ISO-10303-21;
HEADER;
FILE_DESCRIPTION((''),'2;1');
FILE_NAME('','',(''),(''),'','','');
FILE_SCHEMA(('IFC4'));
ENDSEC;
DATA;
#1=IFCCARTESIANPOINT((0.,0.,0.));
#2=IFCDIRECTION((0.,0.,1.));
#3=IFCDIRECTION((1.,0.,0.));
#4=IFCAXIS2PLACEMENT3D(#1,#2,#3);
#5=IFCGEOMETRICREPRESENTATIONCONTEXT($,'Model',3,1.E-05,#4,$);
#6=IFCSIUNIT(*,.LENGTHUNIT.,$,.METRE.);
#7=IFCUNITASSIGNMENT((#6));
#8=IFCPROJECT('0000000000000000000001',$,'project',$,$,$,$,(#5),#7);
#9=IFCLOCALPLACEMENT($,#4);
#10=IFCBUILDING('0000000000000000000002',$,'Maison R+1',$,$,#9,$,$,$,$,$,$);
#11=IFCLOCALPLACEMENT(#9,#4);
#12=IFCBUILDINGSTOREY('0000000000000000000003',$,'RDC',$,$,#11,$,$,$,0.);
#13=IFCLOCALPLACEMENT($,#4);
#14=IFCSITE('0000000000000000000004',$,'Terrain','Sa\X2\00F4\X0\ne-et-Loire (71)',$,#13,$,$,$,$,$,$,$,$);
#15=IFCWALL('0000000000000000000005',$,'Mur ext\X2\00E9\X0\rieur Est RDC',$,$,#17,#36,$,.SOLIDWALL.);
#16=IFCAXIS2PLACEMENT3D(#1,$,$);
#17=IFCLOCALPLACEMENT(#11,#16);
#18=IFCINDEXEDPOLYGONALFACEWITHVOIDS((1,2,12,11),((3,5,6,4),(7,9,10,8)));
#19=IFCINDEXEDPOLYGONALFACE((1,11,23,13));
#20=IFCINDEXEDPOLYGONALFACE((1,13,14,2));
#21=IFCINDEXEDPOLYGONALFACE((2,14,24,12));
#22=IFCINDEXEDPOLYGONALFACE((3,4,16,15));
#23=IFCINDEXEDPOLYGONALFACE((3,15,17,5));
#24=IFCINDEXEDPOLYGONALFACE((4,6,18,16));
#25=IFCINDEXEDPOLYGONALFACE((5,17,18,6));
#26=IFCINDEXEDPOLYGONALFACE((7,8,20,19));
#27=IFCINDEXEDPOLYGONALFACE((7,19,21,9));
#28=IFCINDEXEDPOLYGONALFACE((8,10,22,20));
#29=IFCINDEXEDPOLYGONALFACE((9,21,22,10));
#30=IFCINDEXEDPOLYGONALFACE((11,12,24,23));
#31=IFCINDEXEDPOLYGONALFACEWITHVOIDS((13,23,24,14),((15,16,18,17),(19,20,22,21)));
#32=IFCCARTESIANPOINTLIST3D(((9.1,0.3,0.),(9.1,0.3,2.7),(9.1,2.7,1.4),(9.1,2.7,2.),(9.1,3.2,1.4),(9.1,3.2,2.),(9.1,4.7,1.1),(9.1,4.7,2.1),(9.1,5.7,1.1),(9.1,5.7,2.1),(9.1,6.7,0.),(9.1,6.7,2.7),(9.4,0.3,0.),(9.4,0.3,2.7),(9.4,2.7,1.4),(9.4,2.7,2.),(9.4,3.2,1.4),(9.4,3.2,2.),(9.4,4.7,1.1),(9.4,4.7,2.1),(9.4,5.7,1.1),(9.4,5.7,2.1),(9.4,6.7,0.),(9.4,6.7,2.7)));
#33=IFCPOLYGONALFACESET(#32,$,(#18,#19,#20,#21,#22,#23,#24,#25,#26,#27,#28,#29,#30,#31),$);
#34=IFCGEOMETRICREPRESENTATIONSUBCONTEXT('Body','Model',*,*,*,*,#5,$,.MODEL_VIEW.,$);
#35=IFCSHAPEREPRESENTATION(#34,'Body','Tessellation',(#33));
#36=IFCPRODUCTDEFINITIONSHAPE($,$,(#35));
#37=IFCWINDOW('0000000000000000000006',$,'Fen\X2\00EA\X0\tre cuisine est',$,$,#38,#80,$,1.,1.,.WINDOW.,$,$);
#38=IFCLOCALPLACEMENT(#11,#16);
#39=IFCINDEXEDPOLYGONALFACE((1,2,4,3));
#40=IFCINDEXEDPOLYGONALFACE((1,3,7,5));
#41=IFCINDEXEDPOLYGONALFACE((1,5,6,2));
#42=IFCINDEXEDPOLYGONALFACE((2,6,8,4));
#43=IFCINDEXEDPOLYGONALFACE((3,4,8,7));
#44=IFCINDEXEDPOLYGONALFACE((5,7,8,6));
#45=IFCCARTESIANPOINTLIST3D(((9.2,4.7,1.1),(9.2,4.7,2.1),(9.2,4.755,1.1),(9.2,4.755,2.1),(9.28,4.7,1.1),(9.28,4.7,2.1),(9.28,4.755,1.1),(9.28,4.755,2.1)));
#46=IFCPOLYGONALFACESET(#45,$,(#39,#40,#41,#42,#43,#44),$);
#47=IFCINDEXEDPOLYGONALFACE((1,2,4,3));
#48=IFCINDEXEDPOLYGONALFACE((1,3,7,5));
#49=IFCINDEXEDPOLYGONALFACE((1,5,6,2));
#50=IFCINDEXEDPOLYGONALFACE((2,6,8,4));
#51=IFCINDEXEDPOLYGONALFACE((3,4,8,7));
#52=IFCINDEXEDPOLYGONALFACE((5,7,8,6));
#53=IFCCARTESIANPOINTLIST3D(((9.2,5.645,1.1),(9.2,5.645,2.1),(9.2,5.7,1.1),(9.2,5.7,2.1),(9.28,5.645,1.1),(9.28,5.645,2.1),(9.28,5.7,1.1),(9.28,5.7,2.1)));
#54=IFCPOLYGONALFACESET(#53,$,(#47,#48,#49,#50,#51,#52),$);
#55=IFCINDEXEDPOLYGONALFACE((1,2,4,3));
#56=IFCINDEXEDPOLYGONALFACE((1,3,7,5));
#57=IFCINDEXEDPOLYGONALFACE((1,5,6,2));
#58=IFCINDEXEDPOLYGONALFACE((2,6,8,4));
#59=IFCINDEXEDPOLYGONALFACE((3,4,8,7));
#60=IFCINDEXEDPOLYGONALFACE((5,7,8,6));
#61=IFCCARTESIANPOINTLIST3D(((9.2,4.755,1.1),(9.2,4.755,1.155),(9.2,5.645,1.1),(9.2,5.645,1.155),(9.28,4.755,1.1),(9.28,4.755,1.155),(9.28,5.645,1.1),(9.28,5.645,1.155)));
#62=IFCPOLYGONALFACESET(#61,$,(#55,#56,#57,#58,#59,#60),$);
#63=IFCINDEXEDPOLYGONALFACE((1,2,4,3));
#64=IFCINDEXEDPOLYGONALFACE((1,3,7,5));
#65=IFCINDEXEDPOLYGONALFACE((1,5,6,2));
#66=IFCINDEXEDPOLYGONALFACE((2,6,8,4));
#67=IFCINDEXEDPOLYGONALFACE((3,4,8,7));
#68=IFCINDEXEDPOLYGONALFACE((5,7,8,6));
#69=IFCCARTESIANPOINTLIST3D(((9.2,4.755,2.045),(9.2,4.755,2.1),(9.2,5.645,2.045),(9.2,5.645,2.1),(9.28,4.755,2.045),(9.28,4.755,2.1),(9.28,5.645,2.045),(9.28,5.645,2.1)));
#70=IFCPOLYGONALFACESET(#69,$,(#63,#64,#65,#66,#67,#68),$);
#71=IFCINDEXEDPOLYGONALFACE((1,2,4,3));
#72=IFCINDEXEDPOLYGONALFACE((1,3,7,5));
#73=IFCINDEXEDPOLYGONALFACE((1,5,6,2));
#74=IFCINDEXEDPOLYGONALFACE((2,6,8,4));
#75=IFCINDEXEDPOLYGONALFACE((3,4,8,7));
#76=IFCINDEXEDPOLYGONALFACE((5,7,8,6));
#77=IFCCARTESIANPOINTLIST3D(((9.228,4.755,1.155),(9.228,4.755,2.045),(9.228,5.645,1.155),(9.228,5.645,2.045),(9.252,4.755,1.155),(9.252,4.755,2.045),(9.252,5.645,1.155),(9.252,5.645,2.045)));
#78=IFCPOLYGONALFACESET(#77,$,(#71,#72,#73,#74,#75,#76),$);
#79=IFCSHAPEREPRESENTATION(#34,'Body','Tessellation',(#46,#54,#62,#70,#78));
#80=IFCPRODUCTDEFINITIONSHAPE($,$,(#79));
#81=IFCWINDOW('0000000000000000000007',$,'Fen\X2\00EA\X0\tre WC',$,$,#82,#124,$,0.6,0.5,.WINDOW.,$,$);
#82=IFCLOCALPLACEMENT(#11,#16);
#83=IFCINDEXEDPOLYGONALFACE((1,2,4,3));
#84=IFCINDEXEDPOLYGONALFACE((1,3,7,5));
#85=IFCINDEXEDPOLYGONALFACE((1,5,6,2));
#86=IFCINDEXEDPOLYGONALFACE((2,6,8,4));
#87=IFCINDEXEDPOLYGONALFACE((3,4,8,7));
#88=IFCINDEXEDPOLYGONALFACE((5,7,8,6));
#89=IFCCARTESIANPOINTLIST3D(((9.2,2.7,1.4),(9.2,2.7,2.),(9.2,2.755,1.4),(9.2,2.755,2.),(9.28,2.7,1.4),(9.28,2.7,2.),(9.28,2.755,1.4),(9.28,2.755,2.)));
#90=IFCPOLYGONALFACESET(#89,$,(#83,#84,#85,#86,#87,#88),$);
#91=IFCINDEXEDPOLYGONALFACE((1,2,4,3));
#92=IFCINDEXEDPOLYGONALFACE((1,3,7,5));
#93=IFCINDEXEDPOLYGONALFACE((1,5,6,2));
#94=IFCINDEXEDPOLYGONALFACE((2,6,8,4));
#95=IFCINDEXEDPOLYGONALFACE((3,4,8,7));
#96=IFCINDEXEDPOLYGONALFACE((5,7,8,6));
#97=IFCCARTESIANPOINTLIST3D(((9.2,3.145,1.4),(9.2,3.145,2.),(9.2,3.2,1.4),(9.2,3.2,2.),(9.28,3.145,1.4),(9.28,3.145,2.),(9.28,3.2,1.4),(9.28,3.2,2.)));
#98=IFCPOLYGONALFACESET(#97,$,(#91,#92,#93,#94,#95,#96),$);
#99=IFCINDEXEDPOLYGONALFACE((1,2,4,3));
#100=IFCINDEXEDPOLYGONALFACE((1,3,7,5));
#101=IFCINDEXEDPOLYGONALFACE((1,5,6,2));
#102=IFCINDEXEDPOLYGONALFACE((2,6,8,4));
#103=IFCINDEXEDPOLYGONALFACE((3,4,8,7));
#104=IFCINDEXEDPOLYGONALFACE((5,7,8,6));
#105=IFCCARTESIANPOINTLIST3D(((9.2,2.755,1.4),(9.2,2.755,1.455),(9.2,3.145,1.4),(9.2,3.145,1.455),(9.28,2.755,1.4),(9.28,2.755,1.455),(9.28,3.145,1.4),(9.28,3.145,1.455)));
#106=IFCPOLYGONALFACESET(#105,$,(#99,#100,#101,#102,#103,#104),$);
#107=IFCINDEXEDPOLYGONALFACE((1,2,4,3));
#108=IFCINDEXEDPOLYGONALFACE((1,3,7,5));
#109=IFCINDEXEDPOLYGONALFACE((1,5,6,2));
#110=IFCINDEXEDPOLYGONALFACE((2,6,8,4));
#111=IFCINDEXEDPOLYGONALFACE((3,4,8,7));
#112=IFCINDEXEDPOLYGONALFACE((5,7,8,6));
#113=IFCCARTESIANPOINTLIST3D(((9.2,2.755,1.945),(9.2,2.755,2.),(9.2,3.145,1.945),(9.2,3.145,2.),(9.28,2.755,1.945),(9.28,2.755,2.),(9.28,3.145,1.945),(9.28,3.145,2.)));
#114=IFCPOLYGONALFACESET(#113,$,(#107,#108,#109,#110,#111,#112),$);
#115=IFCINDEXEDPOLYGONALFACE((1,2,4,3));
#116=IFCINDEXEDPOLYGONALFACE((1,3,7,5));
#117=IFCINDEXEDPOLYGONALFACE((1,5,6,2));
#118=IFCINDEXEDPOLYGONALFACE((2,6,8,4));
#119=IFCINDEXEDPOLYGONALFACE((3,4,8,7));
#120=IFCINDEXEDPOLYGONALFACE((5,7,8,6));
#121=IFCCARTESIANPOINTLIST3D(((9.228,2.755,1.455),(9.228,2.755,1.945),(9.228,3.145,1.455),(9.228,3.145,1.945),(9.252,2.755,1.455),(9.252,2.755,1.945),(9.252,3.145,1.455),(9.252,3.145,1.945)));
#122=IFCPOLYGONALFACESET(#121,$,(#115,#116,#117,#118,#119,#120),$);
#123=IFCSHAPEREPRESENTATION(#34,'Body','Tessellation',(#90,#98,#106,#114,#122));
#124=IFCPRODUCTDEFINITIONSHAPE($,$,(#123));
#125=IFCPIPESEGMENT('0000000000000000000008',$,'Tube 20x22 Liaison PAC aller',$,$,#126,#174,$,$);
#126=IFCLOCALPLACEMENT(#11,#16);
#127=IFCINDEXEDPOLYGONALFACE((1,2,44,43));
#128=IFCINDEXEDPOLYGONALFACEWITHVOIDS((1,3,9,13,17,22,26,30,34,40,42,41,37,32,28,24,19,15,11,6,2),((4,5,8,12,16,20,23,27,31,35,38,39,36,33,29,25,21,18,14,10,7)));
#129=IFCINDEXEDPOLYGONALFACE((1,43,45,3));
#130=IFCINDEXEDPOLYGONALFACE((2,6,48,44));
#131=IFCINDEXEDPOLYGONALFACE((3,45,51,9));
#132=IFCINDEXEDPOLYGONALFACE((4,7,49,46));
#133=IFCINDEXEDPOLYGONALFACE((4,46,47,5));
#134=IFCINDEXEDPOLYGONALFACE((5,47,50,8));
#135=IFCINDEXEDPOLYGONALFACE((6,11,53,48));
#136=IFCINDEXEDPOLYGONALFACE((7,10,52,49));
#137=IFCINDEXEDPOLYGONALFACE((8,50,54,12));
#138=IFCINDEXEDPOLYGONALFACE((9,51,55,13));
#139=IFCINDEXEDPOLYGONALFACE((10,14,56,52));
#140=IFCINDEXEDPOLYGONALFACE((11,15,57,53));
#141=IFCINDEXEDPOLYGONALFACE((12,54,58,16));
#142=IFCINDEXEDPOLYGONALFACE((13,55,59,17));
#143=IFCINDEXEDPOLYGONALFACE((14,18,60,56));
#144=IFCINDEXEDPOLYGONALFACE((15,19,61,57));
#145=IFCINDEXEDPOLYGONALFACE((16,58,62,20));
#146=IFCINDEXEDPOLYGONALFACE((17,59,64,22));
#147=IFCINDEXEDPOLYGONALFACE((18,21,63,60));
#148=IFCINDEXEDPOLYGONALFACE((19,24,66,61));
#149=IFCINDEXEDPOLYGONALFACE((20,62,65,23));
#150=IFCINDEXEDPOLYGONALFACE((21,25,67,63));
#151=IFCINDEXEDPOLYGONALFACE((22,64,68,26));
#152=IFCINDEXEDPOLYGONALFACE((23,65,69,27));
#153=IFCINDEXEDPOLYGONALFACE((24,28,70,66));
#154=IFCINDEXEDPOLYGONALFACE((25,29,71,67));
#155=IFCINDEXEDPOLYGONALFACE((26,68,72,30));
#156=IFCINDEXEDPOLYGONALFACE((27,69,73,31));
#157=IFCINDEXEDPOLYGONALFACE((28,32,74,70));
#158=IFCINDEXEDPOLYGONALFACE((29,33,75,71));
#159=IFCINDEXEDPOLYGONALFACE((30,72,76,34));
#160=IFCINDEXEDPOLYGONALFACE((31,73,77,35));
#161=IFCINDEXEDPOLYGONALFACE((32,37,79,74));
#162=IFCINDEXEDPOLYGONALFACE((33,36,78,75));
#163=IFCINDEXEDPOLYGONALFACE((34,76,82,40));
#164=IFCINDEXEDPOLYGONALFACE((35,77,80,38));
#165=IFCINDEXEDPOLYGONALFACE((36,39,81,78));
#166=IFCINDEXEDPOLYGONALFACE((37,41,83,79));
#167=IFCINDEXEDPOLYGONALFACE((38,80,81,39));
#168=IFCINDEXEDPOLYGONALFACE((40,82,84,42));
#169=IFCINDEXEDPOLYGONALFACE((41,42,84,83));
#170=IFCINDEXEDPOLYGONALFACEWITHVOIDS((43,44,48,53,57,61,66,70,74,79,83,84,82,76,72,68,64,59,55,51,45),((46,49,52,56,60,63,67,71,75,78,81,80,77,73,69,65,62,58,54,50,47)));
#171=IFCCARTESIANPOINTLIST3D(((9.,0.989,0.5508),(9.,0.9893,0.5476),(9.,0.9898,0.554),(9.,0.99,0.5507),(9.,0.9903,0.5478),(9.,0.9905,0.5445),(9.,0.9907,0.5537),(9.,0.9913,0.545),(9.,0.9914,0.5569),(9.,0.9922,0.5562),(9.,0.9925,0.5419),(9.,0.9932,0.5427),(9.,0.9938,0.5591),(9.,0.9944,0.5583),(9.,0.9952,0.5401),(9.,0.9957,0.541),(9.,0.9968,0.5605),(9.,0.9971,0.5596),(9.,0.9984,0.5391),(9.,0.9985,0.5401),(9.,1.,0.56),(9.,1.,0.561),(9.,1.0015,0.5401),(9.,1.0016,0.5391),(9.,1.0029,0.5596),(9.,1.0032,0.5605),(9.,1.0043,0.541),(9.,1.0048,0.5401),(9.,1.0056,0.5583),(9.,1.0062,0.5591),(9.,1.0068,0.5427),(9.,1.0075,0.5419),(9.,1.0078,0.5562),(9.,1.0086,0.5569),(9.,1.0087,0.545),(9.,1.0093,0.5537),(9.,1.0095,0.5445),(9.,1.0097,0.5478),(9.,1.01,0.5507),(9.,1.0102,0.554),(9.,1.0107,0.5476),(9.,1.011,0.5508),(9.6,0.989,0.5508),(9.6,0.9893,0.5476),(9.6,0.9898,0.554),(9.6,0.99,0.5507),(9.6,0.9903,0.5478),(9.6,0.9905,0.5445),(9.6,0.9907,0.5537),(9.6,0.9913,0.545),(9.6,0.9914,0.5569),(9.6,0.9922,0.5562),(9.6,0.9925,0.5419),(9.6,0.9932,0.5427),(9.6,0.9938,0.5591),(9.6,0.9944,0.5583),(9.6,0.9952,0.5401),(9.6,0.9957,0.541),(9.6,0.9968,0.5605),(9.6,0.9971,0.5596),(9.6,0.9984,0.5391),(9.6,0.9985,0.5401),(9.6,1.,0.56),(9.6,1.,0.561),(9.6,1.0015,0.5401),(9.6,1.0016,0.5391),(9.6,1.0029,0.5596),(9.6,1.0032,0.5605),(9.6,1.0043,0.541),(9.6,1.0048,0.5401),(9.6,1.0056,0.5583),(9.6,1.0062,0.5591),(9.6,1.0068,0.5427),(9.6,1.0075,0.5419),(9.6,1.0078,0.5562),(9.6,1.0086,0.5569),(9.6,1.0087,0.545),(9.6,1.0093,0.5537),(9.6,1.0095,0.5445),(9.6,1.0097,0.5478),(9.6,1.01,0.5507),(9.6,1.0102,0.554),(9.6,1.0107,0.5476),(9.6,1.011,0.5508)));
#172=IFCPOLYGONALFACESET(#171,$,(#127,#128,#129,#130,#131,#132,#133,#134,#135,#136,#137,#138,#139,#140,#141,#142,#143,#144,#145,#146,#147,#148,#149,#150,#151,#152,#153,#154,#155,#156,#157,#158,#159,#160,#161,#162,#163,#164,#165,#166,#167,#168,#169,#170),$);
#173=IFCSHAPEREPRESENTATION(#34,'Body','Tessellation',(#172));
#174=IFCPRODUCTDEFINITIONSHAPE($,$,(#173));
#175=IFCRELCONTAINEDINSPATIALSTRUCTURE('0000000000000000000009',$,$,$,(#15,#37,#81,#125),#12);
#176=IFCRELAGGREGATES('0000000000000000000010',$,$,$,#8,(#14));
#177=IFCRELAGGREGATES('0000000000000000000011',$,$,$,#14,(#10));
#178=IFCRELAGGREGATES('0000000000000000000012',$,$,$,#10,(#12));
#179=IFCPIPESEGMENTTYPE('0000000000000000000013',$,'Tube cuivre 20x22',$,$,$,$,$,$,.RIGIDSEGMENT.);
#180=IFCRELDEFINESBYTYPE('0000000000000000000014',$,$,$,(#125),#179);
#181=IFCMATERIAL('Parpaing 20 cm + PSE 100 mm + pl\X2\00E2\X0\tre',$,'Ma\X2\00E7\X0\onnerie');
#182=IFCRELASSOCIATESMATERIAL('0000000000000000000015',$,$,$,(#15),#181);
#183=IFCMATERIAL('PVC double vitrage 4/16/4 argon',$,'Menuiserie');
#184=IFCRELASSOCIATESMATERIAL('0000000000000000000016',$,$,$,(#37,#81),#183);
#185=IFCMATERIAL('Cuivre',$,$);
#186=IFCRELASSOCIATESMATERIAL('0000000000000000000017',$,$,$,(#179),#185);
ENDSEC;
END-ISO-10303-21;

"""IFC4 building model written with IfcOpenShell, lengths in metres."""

from ifc_helpers import new_model, si_unit, frame, frame_2d, origin_with_axes, place, context, subcontext, project, spatial, rectangle, hollow_circle, extrude, material, type_object, element, fill, save


model = new_model("IFC4")

# Units and contexts
model_context = context("Model", 3, precision=1e-05, world=origin_with_axes())
body_context = subcontext(model_context, "Body", "Model", "MODEL_VIEW")
ifc_project = project(units=[si_unit("LENGTHUNIT", "METRE")], contexts=[model_context])

# Site, building, storey
site_placement = place(None, origin_with_axes())
site = spatial("IfcSite", under=ifc_project, at=site_placement, Name="Terrain", Description="Saône-et-Loire (71)")
building_placement = place(None, origin_with_axes())
building = spatial("IfcBuilding", under=site, at=building_placement, Name="Maison R+1")
storey_placement = place(building_placement, origin_with_axes())
storey = spatial("IfcBuildingStorey", under=building, at=storey_placement, Name="RDC", Elevation=0.0)

# Wall, openings, windows
ifc_material_1 = material(Name="Parpaing 20 cm + PSE 100 mm + plâtre", Category="Maçonnerie")
wall_placement = place(storey_placement, frame((9.1, 0.3, 0.0), z_axis=(0.0, 0.0, 1.0), x_axis=(1.0, 0.0, 0.0)))
wall = element("IfcWall", 1, at=wall_placement, inside=storey, material=ifc_material_1, Name="Mur extérieur Est RDC", PredefinedType="SOLIDWALL", context=body_context, shape_type="SweptSolid", body=[
    extrude(rectangle(XDim=0.3, YDim=6.4, at=frame_2d((0.15, 3.2))), origin_with_axes(), (0.0, 0.0, 1.0), 2.7),
])
opening_1_placement = place(storey_placement, frame((9.05, 4.7, 1.1), z_axis=(0.0, 0.0, 1.0), x_axis=(1.0, 0.0, 0.0)))
opening_1 = element("IfcOpeningElement", 2, at=opening_1_placement, cuts=wall, context=body_context, shape_type="SweptSolid", body=[
    extrude(rectangle(XDim=0.4, YDim=1.0, at=frame_2d((0.2, 0.5))), origin_with_axes(), (0.0, 0.0, 1.0), 1.0),
])
opening_2_placement = place(storey_placement, frame((9.05, 2.7, 1.4), z_axis=(0.0, 0.0, 1.0), x_axis=(1.0, 0.0, 0.0)))
opening_2 = element("IfcOpeningElement", 3, at=opening_2_placement, cuts=wall, context=body_context, shape_type="SweptSolid", body=[
    extrude(rectangle(XDim=0.4, YDim=0.5, at=frame_2d((0.2, 0.25))), origin_with_axes(), (0.0, 0.0, 1.0), 0.6),
])
ifc_material_2 = material(Name="PVC double vitrage 4/16/4 argon", Category="Menuiserie")
window_1_placement = place(storey_placement, frame((9.2, 4.7, 1.1), z_axis=(0.0, 0.0, 1.0), x_axis=(1.0, 0.0, 0.0)))
window_1 = element("IfcWindow", 4, at=window_1_placement, inside=storey, material=ifc_material_2, Name="Fenêtre cuisine est", OverallHeight=1.0, OverallWidth=1.0, PredefinedType="WINDOW", context=body_context, shape_type="SweptSolid", body=[
    extrude(rectangle(XDim=0.08, YDim=0.055, at=frame_2d((0.04, 0.0275))), origin_with_axes(), (0.0, 0.0, 1.0), 1.0),
    extrude(rectangle(XDim=0.08, YDim=0.055, at=frame_2d((0.04, 0.0275))), frame((0.0, 0.945, 0.0), z_axis=(0.0, 0.0, 1.0), x_axis=(1.0, 0.0, 0.0)), (0.0, 0.0, 1.0), 1.0),
    extrude(rectangle(XDim=0.08, YDim=0.89, at=frame_2d((0.04, 0.445))), frame((0.0, 0.055, 0.0), z_axis=(0.0, 0.0, 1.0), x_axis=(1.0, 0.0, 0.0)), (0.0, 0.0, 1.0), 0.055),
    extrude(rectangle(XDim=0.08, YDim=0.89, at=frame_2d((0.04, 0.445))), frame((0.0, 0.055, 0.945), z_axis=(0.0, 0.0, 1.0), x_axis=(1.0, 0.0, 0.0)), (0.0, 0.0, 1.0), 0.055),
    extrude(rectangle(XDim=0.024, YDim=0.89, at=frame_2d((0.012, 0.445))), frame((0.028, 0.055, 0.055), z_axis=(0.0, 0.0, 1.0), x_axis=(1.0, 0.0, 0.0)), (0.0, 0.0, 1.0), 0.89),
])
fill(opening_1, window_1)
window_2_placement = place(storey_placement, frame((9.2, 2.7, 1.4), z_axis=(0.0, 0.0, 1.0), x_axis=(1.0, 0.0, 0.0)))
window_2 = element("IfcWindow", 5, at=window_2_placement, inside=storey, material=ifc_material_2, Name="Fenêtre WC", OverallHeight=0.6, OverallWidth=0.5, PredefinedType="WINDOW", context=body_context, shape_type="SweptSolid", body=[
    extrude(rectangle(XDim=0.08, YDim=0.055, at=frame_2d((0.04, 0.0275))), origin_with_axes(), (0.0, 0.0, 1.0), 0.6),
    extrude(rectangle(XDim=0.08, YDim=0.055, at=frame_2d((0.04, 0.0275))), frame((0.0, 0.445, 0.0), z_axis=(0.0, 0.0, 1.0), x_axis=(1.0, 0.0, 0.0)), (0.0, 0.0, 1.0), 0.6),
    extrude(rectangle(XDim=0.08, YDim=0.39, at=frame_2d((0.04, 0.195))), frame((0.0, 0.055, 0.0), z_axis=(0.0, 0.0, 1.0), x_axis=(1.0, 0.0, 0.0)), (0.0, 0.0, 1.0), 0.055),
    extrude(rectangle(XDim=0.08, YDim=0.39, at=frame_2d((0.04, 0.195))), frame((0.0, 0.055, 0.545), z_axis=(0.0, 0.0, 1.0), x_axis=(1.0, 0.0, 0.0)), (0.0, 0.0, 1.0), 0.055),
    extrude(rectangle(XDim=0.024, YDim=0.39, at=frame_2d((0.012, 0.195))), frame((0.028, 0.055, 0.055), z_axis=(0.0, 0.0, 1.0), x_axis=(1.0, 0.0, 0.0)), (0.0, 0.0, 1.0), 0.49),
])
fill(opening_2, window_2)

# Pipe segment
ifc_material_3 = material(Name="Cuivre")
pipe_segment_type_1 = type_object("IfcPipeSegmentType", Name="Tube cuivre 20x22", PredefinedType="RIGIDSEGMENT", material=ifc_material_3)
pipe_segment_1_placement = place(storey_placement, frame((9.6, 1.0, 0.55), z_axis=(-1.0, 0.0, 0.0), x_axis=(0.0, 0.0, 1.0)))
element("IfcPipeSegment", 6, at=pipe_segment_1_placement, inside=storey, type_object=pipe_segment_type_1, Name="Tube 20x22 Liaison PAC aller", context=body_context, shape_type="SweptSolid", body=[
    extrude(hollow_circle(Radius=0.011, WallThickness=0.001), origin_with_axes(), (0.0, 0.0, 1.0), 0.6),
])

save(model, "model.ifc")
